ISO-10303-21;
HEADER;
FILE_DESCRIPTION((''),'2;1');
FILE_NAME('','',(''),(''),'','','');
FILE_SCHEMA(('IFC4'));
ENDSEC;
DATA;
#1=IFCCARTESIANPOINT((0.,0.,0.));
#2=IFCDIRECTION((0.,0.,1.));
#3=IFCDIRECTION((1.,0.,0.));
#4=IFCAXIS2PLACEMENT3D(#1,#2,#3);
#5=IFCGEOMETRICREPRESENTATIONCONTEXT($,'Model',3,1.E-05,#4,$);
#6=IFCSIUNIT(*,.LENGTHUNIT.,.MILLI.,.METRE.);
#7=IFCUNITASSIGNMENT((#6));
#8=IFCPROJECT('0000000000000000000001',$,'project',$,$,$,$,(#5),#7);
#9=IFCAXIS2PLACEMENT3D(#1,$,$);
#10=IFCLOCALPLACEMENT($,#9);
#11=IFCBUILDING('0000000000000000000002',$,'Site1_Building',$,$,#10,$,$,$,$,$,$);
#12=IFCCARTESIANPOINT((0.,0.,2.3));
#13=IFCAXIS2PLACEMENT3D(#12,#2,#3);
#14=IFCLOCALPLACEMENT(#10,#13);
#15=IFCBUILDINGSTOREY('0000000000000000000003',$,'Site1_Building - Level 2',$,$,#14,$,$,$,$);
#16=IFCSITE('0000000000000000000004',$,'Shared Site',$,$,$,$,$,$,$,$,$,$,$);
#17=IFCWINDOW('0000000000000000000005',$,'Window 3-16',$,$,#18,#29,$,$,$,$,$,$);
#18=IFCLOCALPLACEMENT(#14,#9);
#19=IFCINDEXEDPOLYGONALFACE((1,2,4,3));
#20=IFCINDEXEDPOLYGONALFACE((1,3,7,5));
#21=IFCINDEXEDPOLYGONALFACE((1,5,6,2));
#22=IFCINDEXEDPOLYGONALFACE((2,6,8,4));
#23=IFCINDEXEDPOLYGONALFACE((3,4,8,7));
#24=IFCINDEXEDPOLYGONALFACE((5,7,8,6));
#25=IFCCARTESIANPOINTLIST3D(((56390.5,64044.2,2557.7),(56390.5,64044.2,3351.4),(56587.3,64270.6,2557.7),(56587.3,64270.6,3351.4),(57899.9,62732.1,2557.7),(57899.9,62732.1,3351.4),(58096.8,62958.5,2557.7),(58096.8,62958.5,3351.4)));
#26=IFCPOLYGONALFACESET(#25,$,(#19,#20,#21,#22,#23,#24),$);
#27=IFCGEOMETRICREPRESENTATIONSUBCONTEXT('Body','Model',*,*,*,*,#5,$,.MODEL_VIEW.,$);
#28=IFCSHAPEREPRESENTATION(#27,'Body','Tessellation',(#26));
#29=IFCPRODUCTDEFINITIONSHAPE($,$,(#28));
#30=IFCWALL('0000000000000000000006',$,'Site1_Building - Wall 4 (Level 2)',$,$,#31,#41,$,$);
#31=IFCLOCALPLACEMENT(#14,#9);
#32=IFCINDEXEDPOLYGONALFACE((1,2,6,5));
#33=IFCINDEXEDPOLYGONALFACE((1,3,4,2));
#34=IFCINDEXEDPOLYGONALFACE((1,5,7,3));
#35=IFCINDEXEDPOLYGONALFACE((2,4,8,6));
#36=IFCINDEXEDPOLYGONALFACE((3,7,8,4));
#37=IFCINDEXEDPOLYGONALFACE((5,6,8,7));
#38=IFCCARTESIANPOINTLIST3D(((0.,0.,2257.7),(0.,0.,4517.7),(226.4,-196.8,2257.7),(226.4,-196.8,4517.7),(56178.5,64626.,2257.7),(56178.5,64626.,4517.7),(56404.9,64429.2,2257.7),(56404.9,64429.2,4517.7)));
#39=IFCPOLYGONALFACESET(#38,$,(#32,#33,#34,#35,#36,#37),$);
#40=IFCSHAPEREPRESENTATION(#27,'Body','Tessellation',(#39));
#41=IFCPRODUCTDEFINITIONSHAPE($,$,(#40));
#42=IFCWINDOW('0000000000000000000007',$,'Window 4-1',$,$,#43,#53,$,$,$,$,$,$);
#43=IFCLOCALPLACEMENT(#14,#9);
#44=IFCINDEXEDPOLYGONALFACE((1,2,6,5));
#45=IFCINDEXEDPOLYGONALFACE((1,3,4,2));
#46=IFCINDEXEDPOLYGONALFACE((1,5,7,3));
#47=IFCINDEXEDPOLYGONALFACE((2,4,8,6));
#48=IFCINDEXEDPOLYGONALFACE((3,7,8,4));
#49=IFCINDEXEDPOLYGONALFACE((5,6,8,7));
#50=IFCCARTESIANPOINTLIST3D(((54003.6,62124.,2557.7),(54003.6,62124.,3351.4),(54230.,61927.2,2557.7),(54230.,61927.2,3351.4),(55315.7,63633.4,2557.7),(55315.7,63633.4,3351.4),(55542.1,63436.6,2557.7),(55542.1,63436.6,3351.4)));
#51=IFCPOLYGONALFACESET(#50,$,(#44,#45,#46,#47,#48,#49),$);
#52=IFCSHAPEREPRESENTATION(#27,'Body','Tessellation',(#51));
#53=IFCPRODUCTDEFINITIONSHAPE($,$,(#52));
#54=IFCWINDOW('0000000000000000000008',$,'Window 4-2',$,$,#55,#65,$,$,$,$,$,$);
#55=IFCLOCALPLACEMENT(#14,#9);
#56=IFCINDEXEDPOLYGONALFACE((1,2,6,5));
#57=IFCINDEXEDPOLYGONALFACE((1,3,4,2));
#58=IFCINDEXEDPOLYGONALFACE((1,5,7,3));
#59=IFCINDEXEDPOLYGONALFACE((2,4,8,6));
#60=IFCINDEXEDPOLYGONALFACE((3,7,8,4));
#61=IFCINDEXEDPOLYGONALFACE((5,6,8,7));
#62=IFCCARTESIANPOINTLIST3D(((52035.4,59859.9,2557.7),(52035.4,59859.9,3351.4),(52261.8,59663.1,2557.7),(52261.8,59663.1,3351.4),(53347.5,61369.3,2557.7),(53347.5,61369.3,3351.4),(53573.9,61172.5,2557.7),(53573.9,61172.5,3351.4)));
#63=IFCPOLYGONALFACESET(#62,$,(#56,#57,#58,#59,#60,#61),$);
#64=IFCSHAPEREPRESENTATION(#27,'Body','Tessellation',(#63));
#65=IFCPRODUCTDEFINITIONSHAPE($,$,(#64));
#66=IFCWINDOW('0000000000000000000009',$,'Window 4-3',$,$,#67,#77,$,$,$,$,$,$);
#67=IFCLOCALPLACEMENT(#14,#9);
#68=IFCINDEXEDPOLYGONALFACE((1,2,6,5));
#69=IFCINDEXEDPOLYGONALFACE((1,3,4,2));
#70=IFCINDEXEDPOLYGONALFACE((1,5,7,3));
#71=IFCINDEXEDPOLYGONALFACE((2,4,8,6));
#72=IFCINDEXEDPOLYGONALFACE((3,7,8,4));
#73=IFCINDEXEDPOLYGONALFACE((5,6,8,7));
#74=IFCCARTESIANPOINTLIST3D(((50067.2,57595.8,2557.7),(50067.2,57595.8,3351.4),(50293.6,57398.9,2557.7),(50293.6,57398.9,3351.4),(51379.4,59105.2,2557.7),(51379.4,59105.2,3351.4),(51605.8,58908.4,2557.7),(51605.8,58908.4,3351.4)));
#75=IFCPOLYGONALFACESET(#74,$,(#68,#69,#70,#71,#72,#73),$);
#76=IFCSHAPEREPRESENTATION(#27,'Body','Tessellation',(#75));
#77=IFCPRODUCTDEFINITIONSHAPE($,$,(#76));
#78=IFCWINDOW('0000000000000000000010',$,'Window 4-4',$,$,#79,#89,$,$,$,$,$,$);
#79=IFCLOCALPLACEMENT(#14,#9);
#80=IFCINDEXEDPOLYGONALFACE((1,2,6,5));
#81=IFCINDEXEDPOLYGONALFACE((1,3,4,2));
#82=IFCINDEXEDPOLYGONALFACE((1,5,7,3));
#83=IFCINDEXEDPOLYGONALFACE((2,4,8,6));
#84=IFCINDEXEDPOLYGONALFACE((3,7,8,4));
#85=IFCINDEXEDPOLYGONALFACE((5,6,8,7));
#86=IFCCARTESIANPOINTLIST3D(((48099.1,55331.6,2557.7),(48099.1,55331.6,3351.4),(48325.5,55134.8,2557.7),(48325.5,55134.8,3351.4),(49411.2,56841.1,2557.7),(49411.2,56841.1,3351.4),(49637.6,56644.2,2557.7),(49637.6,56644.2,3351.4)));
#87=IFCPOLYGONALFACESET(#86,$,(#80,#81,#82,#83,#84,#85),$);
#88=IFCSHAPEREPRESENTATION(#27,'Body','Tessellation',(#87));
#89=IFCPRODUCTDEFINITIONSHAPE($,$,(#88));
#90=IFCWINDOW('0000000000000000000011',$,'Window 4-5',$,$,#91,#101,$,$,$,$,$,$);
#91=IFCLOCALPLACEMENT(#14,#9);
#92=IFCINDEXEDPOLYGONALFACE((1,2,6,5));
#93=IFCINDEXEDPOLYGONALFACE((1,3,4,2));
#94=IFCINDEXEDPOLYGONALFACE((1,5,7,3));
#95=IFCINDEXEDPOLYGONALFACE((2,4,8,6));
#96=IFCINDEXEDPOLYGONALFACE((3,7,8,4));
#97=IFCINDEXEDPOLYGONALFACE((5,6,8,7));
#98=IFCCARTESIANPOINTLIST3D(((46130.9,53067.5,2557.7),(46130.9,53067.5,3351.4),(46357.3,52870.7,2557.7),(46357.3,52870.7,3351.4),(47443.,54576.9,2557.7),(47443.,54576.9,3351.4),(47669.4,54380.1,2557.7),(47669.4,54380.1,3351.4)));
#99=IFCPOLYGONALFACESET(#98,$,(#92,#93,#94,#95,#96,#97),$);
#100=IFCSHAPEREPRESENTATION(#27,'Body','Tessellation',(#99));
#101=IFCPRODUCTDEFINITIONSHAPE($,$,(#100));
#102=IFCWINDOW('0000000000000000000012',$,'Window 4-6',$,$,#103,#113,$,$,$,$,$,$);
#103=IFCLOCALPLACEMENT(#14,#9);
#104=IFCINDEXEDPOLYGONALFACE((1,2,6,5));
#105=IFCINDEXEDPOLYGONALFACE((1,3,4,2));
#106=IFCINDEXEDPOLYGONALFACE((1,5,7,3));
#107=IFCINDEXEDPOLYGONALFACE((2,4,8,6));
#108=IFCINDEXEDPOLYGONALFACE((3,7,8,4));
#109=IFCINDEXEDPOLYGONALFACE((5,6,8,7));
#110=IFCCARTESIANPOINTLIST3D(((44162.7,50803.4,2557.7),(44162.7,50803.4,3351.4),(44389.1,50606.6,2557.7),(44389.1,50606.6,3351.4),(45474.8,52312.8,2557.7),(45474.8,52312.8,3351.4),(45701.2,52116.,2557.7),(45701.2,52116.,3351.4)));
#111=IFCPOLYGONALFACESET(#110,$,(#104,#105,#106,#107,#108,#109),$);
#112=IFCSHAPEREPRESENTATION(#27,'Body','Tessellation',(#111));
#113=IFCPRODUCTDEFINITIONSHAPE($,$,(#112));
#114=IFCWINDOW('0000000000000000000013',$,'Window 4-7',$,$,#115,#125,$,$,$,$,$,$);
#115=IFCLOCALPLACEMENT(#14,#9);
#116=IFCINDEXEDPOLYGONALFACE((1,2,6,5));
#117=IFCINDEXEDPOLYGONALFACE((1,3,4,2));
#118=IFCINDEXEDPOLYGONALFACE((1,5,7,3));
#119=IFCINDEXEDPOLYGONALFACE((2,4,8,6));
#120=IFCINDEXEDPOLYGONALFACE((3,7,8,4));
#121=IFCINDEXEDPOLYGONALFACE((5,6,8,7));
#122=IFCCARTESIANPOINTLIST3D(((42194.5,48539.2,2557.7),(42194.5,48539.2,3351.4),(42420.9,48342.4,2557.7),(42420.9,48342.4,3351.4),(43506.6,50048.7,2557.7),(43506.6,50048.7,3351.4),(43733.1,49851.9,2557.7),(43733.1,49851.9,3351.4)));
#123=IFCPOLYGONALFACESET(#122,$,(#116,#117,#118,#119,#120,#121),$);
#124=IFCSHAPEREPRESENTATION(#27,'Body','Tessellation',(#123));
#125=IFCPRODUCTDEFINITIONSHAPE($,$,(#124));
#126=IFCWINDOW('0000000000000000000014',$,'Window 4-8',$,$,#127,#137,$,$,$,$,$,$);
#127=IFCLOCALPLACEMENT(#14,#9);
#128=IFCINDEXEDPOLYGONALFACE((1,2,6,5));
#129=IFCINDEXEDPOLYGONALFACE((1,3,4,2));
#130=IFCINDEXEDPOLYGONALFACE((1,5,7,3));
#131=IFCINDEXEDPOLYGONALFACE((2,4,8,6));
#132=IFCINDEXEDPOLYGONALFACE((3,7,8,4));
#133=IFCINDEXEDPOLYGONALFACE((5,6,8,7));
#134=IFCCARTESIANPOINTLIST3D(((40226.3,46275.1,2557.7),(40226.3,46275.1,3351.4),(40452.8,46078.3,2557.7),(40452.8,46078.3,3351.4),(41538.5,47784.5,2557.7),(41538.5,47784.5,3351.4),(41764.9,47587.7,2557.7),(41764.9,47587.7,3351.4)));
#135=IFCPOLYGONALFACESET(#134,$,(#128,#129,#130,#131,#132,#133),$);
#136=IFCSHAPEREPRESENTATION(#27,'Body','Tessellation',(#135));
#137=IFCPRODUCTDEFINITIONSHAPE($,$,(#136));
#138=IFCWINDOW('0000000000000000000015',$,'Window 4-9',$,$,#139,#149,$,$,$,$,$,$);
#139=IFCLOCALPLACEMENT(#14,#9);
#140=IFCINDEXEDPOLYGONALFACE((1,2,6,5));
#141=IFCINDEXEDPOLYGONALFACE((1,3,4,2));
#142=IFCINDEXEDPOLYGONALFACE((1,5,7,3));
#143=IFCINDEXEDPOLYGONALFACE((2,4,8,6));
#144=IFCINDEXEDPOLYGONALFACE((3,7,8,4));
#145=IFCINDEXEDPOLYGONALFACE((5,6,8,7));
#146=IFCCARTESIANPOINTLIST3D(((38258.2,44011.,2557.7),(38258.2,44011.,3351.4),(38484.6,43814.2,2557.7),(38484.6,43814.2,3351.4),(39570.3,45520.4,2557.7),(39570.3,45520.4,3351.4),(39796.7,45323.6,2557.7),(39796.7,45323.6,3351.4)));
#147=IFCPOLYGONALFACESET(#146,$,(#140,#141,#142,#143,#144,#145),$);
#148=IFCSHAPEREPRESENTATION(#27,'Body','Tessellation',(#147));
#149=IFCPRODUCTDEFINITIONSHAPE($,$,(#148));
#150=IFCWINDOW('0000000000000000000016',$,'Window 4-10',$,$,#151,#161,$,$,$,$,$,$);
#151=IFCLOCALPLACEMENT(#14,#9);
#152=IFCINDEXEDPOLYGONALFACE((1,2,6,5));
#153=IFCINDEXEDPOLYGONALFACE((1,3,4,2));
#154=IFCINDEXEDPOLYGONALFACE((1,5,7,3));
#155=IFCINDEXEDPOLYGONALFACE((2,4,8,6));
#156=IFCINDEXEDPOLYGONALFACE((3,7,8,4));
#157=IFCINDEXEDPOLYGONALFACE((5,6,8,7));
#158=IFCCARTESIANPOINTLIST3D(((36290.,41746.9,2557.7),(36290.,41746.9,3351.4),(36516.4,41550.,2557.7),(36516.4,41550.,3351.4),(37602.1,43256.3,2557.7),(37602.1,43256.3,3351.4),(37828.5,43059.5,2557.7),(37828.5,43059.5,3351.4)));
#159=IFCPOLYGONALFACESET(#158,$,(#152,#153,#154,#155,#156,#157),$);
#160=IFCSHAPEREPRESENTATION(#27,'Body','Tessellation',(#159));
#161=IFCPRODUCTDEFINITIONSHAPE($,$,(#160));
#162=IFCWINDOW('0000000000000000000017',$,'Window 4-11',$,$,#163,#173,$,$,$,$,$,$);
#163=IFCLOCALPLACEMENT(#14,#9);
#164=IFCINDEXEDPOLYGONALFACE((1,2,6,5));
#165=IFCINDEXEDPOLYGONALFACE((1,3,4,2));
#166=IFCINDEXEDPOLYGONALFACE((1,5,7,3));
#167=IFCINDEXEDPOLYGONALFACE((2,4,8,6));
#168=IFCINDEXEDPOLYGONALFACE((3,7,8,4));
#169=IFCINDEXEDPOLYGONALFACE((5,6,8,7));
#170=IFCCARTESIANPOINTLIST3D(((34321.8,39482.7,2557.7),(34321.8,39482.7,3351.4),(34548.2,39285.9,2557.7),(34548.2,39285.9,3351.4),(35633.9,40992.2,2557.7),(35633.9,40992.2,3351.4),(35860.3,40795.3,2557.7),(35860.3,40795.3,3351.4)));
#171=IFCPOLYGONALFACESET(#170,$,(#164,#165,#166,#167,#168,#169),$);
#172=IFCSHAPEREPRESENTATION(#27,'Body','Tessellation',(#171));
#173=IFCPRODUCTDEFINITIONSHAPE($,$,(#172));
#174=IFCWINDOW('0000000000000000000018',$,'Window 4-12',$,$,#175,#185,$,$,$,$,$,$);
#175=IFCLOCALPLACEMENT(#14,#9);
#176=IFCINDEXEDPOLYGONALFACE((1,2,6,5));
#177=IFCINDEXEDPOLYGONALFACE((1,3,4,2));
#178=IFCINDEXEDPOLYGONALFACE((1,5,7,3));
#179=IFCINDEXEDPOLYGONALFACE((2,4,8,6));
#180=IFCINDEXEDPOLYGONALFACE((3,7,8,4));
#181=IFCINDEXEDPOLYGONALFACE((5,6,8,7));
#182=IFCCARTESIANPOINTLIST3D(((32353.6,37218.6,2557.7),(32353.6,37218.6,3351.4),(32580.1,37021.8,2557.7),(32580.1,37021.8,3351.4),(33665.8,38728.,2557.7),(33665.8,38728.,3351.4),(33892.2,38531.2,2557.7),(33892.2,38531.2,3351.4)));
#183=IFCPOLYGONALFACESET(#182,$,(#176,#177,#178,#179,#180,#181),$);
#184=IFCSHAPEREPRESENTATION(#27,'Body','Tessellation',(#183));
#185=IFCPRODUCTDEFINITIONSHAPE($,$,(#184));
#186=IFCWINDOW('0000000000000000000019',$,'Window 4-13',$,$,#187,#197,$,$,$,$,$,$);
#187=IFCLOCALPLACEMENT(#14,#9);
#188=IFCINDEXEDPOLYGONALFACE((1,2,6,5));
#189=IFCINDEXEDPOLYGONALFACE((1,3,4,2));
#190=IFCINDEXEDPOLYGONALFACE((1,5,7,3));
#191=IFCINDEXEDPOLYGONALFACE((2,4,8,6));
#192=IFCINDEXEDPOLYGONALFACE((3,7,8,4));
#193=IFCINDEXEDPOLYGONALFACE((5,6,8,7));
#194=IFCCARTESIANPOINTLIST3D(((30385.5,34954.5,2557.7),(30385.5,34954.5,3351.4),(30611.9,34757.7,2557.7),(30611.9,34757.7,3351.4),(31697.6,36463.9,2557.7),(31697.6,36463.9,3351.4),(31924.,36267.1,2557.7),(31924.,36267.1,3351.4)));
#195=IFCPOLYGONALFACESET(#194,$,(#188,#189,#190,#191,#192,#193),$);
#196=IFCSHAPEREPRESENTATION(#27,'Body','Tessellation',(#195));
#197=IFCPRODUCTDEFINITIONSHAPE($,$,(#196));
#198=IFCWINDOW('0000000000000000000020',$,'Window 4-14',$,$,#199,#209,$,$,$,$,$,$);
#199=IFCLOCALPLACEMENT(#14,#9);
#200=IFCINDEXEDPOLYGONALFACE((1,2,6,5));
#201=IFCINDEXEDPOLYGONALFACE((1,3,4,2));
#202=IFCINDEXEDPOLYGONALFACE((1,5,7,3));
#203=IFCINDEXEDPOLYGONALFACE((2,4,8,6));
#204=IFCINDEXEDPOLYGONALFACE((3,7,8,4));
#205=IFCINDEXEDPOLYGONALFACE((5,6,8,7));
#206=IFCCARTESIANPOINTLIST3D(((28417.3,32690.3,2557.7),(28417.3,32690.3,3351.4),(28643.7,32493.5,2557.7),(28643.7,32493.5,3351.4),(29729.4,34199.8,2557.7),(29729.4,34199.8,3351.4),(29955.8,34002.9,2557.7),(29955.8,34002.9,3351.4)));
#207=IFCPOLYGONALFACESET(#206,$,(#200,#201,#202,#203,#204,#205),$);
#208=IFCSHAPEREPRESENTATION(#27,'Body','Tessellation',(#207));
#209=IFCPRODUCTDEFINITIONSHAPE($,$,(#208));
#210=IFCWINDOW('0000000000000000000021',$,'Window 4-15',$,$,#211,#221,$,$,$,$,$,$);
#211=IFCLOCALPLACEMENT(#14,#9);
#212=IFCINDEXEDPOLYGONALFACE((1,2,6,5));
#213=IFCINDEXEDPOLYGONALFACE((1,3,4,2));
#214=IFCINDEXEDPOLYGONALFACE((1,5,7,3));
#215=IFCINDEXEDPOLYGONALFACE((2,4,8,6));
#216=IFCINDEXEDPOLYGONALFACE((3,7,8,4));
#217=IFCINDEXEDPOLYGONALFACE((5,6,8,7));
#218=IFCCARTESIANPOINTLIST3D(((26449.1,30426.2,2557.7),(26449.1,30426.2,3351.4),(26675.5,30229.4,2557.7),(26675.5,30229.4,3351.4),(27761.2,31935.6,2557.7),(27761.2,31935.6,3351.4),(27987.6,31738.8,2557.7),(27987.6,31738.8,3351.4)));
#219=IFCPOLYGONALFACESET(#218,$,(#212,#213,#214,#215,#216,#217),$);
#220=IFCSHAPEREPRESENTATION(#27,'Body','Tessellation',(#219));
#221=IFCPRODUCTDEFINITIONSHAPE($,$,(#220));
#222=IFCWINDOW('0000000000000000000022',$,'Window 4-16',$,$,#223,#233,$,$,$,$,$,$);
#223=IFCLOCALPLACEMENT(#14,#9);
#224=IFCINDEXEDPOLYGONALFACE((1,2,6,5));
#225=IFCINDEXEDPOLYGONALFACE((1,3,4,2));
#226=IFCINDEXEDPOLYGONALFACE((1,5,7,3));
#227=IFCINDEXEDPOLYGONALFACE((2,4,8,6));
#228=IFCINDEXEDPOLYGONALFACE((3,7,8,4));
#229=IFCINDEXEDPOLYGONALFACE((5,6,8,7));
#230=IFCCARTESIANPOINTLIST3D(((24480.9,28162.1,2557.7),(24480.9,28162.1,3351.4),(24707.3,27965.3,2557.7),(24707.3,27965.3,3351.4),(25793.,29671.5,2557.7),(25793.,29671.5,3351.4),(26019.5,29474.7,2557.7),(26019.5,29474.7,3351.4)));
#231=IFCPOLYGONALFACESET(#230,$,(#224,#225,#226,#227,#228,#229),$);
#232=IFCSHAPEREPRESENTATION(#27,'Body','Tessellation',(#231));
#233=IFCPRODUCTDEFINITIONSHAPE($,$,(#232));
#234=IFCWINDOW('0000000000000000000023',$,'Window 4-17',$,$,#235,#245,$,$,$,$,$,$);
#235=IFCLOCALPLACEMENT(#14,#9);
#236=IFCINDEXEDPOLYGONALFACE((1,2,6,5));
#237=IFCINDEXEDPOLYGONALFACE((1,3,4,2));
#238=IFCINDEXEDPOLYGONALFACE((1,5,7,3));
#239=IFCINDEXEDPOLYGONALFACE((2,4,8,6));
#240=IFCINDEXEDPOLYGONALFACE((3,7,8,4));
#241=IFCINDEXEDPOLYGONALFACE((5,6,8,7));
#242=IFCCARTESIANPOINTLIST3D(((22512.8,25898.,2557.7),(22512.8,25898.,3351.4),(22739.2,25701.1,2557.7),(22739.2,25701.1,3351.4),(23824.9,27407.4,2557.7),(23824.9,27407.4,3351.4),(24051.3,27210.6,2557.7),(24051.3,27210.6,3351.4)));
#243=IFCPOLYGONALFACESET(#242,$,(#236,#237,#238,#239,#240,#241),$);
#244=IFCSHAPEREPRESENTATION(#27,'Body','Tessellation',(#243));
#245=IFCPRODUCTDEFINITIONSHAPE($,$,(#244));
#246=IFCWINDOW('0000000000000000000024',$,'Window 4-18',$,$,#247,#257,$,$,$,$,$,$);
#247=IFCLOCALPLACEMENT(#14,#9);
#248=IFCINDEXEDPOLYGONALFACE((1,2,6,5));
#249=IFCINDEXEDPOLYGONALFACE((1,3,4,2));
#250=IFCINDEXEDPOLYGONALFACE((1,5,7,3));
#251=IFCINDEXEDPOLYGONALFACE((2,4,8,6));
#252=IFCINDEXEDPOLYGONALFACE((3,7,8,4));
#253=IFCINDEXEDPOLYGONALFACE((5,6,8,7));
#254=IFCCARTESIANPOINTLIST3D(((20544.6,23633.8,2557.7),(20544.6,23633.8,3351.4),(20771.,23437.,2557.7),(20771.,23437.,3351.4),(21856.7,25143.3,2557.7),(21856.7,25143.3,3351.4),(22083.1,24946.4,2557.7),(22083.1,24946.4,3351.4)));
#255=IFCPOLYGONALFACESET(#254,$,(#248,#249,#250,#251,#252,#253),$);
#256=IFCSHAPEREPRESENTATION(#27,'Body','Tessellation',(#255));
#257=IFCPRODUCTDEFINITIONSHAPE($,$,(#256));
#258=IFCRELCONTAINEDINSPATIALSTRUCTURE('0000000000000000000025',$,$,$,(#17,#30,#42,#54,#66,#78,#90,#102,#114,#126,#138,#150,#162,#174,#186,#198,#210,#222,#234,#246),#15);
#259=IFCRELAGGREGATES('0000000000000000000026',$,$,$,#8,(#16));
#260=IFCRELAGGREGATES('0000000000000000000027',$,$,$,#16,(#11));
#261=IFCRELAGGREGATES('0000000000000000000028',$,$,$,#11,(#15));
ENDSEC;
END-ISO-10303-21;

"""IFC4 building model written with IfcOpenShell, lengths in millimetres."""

from ifc_helpers import new_model, si_unit, frame, origin, origin_with_axes, place, context, subcontext, project, spatial, indexed_curve, outline, extrude, element, save


model = new_model("IFC4")

# Units and contexts
model_context = context("Model", 3, precision=1e-05, world=origin_with_axes())
body_context = subcontext(model_context, "Body", "Model", "MODEL_VIEW")
ifc_project = project(units=[si_unit("LENGTHUNIT", "METRE", prefix="MILLI")], contexts=[model_context])

# Site, building, storey
site = spatial("IfcSite", under=ifc_project, Name="Shared Site")
building_placement = place(None, origin())
building = spatial("IfcBuilding", under=site, at=building_placement, Name="Site1_Building")
storey_placement = place(building_placement, frame((0.0, 0.0, 2.3), z_axis=(0.0, 0.0, 1.0), x_axis=(1.0, 0.0, 0.0)))
storey = spatial("IfcBuildingStorey", under=building, at=storey_placement, Name="Site1_Building - Level 2")

# Window
window_placement = place(storey_placement, frame((58096.8, 62958.5, 2557.7), z_axis=(0.0, 0.0, 1.0), x_axis=(-0.75471, 0.656059, 0.0)))
element("IfcWindow", 1, at=window_placement, inside=storey, Name="Window 3-16", context=body_context, shape_type="SweptSolid", body=[
    extrude(outline(indexed_curve([(0.0, 0.0), (0.0, 300.0), (2000.0, 300.0), (2000.0, 0.0), (0.0, 0.0)], self_intersect=False)), origin_with_axes(), (0.0, 0.0, 1.0), 793.6),
])

# Wall
wall_placement = place(storey_placement, frame((56178.5, 64626.0, 2257.7), z_axis=(0.0, 0.0, 1.0), x_axis=(-0.656059, -0.75471, 0.0)))
element("IfcWall", 2, at=wall_placement, inside=storey, Name="Site1_Building - Wall 4 (Level 2)", context=body_context, shape_type="SweptSolid", body=[
    extrude(outline(indexed_curve([(0.0, 0.0), (0.0, 300.0), (85630.3, 300.0), (85630.3, 0.0), (0.0, 0.0)], self_intersect=False)), origin_with_axes(), (0.0, 0.0, 1.0), 2260.0),
])

# Windows
for number, where, z_axis, x_axis, name in (
    (3, (55315.7, 63633.4, 2557.7), (0.0, 0.0, 1.0), (-0.656059, -0.75471, 0.0), "Window 4-1"),
    (4, (53347.5, 61369.3, 2557.7), (0.0, 0.0, 1.0), (-0.656059, -0.75471, 0.0), "Window 4-2"),
    (5, (51379.4, 59105.2, 2557.7), (0.0, 0.0, 1.0), (-0.656059, -0.75471, 0.0), "Window 4-3"),
    (6, (49411.2, 56841.1, 2557.7), (0.0, 0.0, 1.0), (-0.656059, -0.75471, 0.0), "Window 4-4"),
    (7, (47443.0, 54576.9, 2557.7), (0.0, 0.0, 1.0), (-0.656059, -0.75471, 0.0), "Window 4-5"),
    (8, (45474.8, 52312.8, 2557.7), (0.0, 0.0, 1.0), (-0.656059, -0.75471, 0.0), "Window 4-6"),
    (9, (43506.6, 50048.7, 2557.7), (0.0, 0.0, 1.0), (-0.656059, -0.75471, 0.0), "Window 4-7"),
    (10, (41538.5, 47784.5, 2557.7), (0.0, 0.0, 1.0), (-0.656059, -0.75471, 0.0), "Window 4-8"),
    (11, (39570.3, 45520.4, 2557.7), (0.0, 0.0, 1.0), (-0.656059, -0.75471, 0.0), "Window 4-9"),
    (12, (37602.1, 43256.3, 2557.7), (0.0, 0.0, 1.0), (-0.656059, -0.75471, 0.0), "Window 4-10"),
    (13, (35633.9, 40992.2, 2557.7), (0.0, 0.0, 1.0), (-0.656059, -0.75471, 0.0), "Window 4-11"),
    (14, (33665.8, 38728.0, 2557.7), (0.0, 0.0, 1.0), (-0.656059, -0.75471, 0.0), "Window 4-12"),
    (15, (31697.6, 36463.9, 2557.7), (0.0, 0.0, 1.0), (-0.656059, -0.75471, 0.0), "Window 4-13"),
    (16, (29729.4, 34199.8, 2557.7), (0.0, 0.0, 1.0), (-0.656059, -0.75471, 0.0), "Window 4-14"),
    (17, (27761.2, 31935.6, 2557.7), (0.0, 0.0, 1.0), (-0.656059, -0.75471, 0.0), "Window 4-15"),
    (18, (25793.0, 29671.5, 2557.7), (0.0, 0.0, 1.0), (-0.656059, -0.75471, 0.0), "Window 4-16"),
    (19, (23824.9, 27407.4, 2557.7), (0.0, 0.0, 1.0), (-0.656059, -0.75471, 0.0), "Window 4-17"),
    (20, (21856.7, 25143.3, 2557.7), (0.0, 0.0, 1.0), (-0.656059, -0.75471, 0.0), "Window 4-18"),
):
    element("IfcWindow", number, at=place(storey_placement, frame(where, z_axis=z_axis, x_axis=x_axis)), inside=storey, Name=name, context=body_context, shape_type="SweptSolid", body=[
        extrude(outline(indexed_curve([(0.0, 0.0), (0.0, 300.0), (2000.0, 300.0), (2000.0, 0.0), (0.0, 0.0)], self_intersect=False)), origin_with_axes(), (0.0, 0.0, 1.0), 793.6),
    ])

save(model, "model.ifc")
